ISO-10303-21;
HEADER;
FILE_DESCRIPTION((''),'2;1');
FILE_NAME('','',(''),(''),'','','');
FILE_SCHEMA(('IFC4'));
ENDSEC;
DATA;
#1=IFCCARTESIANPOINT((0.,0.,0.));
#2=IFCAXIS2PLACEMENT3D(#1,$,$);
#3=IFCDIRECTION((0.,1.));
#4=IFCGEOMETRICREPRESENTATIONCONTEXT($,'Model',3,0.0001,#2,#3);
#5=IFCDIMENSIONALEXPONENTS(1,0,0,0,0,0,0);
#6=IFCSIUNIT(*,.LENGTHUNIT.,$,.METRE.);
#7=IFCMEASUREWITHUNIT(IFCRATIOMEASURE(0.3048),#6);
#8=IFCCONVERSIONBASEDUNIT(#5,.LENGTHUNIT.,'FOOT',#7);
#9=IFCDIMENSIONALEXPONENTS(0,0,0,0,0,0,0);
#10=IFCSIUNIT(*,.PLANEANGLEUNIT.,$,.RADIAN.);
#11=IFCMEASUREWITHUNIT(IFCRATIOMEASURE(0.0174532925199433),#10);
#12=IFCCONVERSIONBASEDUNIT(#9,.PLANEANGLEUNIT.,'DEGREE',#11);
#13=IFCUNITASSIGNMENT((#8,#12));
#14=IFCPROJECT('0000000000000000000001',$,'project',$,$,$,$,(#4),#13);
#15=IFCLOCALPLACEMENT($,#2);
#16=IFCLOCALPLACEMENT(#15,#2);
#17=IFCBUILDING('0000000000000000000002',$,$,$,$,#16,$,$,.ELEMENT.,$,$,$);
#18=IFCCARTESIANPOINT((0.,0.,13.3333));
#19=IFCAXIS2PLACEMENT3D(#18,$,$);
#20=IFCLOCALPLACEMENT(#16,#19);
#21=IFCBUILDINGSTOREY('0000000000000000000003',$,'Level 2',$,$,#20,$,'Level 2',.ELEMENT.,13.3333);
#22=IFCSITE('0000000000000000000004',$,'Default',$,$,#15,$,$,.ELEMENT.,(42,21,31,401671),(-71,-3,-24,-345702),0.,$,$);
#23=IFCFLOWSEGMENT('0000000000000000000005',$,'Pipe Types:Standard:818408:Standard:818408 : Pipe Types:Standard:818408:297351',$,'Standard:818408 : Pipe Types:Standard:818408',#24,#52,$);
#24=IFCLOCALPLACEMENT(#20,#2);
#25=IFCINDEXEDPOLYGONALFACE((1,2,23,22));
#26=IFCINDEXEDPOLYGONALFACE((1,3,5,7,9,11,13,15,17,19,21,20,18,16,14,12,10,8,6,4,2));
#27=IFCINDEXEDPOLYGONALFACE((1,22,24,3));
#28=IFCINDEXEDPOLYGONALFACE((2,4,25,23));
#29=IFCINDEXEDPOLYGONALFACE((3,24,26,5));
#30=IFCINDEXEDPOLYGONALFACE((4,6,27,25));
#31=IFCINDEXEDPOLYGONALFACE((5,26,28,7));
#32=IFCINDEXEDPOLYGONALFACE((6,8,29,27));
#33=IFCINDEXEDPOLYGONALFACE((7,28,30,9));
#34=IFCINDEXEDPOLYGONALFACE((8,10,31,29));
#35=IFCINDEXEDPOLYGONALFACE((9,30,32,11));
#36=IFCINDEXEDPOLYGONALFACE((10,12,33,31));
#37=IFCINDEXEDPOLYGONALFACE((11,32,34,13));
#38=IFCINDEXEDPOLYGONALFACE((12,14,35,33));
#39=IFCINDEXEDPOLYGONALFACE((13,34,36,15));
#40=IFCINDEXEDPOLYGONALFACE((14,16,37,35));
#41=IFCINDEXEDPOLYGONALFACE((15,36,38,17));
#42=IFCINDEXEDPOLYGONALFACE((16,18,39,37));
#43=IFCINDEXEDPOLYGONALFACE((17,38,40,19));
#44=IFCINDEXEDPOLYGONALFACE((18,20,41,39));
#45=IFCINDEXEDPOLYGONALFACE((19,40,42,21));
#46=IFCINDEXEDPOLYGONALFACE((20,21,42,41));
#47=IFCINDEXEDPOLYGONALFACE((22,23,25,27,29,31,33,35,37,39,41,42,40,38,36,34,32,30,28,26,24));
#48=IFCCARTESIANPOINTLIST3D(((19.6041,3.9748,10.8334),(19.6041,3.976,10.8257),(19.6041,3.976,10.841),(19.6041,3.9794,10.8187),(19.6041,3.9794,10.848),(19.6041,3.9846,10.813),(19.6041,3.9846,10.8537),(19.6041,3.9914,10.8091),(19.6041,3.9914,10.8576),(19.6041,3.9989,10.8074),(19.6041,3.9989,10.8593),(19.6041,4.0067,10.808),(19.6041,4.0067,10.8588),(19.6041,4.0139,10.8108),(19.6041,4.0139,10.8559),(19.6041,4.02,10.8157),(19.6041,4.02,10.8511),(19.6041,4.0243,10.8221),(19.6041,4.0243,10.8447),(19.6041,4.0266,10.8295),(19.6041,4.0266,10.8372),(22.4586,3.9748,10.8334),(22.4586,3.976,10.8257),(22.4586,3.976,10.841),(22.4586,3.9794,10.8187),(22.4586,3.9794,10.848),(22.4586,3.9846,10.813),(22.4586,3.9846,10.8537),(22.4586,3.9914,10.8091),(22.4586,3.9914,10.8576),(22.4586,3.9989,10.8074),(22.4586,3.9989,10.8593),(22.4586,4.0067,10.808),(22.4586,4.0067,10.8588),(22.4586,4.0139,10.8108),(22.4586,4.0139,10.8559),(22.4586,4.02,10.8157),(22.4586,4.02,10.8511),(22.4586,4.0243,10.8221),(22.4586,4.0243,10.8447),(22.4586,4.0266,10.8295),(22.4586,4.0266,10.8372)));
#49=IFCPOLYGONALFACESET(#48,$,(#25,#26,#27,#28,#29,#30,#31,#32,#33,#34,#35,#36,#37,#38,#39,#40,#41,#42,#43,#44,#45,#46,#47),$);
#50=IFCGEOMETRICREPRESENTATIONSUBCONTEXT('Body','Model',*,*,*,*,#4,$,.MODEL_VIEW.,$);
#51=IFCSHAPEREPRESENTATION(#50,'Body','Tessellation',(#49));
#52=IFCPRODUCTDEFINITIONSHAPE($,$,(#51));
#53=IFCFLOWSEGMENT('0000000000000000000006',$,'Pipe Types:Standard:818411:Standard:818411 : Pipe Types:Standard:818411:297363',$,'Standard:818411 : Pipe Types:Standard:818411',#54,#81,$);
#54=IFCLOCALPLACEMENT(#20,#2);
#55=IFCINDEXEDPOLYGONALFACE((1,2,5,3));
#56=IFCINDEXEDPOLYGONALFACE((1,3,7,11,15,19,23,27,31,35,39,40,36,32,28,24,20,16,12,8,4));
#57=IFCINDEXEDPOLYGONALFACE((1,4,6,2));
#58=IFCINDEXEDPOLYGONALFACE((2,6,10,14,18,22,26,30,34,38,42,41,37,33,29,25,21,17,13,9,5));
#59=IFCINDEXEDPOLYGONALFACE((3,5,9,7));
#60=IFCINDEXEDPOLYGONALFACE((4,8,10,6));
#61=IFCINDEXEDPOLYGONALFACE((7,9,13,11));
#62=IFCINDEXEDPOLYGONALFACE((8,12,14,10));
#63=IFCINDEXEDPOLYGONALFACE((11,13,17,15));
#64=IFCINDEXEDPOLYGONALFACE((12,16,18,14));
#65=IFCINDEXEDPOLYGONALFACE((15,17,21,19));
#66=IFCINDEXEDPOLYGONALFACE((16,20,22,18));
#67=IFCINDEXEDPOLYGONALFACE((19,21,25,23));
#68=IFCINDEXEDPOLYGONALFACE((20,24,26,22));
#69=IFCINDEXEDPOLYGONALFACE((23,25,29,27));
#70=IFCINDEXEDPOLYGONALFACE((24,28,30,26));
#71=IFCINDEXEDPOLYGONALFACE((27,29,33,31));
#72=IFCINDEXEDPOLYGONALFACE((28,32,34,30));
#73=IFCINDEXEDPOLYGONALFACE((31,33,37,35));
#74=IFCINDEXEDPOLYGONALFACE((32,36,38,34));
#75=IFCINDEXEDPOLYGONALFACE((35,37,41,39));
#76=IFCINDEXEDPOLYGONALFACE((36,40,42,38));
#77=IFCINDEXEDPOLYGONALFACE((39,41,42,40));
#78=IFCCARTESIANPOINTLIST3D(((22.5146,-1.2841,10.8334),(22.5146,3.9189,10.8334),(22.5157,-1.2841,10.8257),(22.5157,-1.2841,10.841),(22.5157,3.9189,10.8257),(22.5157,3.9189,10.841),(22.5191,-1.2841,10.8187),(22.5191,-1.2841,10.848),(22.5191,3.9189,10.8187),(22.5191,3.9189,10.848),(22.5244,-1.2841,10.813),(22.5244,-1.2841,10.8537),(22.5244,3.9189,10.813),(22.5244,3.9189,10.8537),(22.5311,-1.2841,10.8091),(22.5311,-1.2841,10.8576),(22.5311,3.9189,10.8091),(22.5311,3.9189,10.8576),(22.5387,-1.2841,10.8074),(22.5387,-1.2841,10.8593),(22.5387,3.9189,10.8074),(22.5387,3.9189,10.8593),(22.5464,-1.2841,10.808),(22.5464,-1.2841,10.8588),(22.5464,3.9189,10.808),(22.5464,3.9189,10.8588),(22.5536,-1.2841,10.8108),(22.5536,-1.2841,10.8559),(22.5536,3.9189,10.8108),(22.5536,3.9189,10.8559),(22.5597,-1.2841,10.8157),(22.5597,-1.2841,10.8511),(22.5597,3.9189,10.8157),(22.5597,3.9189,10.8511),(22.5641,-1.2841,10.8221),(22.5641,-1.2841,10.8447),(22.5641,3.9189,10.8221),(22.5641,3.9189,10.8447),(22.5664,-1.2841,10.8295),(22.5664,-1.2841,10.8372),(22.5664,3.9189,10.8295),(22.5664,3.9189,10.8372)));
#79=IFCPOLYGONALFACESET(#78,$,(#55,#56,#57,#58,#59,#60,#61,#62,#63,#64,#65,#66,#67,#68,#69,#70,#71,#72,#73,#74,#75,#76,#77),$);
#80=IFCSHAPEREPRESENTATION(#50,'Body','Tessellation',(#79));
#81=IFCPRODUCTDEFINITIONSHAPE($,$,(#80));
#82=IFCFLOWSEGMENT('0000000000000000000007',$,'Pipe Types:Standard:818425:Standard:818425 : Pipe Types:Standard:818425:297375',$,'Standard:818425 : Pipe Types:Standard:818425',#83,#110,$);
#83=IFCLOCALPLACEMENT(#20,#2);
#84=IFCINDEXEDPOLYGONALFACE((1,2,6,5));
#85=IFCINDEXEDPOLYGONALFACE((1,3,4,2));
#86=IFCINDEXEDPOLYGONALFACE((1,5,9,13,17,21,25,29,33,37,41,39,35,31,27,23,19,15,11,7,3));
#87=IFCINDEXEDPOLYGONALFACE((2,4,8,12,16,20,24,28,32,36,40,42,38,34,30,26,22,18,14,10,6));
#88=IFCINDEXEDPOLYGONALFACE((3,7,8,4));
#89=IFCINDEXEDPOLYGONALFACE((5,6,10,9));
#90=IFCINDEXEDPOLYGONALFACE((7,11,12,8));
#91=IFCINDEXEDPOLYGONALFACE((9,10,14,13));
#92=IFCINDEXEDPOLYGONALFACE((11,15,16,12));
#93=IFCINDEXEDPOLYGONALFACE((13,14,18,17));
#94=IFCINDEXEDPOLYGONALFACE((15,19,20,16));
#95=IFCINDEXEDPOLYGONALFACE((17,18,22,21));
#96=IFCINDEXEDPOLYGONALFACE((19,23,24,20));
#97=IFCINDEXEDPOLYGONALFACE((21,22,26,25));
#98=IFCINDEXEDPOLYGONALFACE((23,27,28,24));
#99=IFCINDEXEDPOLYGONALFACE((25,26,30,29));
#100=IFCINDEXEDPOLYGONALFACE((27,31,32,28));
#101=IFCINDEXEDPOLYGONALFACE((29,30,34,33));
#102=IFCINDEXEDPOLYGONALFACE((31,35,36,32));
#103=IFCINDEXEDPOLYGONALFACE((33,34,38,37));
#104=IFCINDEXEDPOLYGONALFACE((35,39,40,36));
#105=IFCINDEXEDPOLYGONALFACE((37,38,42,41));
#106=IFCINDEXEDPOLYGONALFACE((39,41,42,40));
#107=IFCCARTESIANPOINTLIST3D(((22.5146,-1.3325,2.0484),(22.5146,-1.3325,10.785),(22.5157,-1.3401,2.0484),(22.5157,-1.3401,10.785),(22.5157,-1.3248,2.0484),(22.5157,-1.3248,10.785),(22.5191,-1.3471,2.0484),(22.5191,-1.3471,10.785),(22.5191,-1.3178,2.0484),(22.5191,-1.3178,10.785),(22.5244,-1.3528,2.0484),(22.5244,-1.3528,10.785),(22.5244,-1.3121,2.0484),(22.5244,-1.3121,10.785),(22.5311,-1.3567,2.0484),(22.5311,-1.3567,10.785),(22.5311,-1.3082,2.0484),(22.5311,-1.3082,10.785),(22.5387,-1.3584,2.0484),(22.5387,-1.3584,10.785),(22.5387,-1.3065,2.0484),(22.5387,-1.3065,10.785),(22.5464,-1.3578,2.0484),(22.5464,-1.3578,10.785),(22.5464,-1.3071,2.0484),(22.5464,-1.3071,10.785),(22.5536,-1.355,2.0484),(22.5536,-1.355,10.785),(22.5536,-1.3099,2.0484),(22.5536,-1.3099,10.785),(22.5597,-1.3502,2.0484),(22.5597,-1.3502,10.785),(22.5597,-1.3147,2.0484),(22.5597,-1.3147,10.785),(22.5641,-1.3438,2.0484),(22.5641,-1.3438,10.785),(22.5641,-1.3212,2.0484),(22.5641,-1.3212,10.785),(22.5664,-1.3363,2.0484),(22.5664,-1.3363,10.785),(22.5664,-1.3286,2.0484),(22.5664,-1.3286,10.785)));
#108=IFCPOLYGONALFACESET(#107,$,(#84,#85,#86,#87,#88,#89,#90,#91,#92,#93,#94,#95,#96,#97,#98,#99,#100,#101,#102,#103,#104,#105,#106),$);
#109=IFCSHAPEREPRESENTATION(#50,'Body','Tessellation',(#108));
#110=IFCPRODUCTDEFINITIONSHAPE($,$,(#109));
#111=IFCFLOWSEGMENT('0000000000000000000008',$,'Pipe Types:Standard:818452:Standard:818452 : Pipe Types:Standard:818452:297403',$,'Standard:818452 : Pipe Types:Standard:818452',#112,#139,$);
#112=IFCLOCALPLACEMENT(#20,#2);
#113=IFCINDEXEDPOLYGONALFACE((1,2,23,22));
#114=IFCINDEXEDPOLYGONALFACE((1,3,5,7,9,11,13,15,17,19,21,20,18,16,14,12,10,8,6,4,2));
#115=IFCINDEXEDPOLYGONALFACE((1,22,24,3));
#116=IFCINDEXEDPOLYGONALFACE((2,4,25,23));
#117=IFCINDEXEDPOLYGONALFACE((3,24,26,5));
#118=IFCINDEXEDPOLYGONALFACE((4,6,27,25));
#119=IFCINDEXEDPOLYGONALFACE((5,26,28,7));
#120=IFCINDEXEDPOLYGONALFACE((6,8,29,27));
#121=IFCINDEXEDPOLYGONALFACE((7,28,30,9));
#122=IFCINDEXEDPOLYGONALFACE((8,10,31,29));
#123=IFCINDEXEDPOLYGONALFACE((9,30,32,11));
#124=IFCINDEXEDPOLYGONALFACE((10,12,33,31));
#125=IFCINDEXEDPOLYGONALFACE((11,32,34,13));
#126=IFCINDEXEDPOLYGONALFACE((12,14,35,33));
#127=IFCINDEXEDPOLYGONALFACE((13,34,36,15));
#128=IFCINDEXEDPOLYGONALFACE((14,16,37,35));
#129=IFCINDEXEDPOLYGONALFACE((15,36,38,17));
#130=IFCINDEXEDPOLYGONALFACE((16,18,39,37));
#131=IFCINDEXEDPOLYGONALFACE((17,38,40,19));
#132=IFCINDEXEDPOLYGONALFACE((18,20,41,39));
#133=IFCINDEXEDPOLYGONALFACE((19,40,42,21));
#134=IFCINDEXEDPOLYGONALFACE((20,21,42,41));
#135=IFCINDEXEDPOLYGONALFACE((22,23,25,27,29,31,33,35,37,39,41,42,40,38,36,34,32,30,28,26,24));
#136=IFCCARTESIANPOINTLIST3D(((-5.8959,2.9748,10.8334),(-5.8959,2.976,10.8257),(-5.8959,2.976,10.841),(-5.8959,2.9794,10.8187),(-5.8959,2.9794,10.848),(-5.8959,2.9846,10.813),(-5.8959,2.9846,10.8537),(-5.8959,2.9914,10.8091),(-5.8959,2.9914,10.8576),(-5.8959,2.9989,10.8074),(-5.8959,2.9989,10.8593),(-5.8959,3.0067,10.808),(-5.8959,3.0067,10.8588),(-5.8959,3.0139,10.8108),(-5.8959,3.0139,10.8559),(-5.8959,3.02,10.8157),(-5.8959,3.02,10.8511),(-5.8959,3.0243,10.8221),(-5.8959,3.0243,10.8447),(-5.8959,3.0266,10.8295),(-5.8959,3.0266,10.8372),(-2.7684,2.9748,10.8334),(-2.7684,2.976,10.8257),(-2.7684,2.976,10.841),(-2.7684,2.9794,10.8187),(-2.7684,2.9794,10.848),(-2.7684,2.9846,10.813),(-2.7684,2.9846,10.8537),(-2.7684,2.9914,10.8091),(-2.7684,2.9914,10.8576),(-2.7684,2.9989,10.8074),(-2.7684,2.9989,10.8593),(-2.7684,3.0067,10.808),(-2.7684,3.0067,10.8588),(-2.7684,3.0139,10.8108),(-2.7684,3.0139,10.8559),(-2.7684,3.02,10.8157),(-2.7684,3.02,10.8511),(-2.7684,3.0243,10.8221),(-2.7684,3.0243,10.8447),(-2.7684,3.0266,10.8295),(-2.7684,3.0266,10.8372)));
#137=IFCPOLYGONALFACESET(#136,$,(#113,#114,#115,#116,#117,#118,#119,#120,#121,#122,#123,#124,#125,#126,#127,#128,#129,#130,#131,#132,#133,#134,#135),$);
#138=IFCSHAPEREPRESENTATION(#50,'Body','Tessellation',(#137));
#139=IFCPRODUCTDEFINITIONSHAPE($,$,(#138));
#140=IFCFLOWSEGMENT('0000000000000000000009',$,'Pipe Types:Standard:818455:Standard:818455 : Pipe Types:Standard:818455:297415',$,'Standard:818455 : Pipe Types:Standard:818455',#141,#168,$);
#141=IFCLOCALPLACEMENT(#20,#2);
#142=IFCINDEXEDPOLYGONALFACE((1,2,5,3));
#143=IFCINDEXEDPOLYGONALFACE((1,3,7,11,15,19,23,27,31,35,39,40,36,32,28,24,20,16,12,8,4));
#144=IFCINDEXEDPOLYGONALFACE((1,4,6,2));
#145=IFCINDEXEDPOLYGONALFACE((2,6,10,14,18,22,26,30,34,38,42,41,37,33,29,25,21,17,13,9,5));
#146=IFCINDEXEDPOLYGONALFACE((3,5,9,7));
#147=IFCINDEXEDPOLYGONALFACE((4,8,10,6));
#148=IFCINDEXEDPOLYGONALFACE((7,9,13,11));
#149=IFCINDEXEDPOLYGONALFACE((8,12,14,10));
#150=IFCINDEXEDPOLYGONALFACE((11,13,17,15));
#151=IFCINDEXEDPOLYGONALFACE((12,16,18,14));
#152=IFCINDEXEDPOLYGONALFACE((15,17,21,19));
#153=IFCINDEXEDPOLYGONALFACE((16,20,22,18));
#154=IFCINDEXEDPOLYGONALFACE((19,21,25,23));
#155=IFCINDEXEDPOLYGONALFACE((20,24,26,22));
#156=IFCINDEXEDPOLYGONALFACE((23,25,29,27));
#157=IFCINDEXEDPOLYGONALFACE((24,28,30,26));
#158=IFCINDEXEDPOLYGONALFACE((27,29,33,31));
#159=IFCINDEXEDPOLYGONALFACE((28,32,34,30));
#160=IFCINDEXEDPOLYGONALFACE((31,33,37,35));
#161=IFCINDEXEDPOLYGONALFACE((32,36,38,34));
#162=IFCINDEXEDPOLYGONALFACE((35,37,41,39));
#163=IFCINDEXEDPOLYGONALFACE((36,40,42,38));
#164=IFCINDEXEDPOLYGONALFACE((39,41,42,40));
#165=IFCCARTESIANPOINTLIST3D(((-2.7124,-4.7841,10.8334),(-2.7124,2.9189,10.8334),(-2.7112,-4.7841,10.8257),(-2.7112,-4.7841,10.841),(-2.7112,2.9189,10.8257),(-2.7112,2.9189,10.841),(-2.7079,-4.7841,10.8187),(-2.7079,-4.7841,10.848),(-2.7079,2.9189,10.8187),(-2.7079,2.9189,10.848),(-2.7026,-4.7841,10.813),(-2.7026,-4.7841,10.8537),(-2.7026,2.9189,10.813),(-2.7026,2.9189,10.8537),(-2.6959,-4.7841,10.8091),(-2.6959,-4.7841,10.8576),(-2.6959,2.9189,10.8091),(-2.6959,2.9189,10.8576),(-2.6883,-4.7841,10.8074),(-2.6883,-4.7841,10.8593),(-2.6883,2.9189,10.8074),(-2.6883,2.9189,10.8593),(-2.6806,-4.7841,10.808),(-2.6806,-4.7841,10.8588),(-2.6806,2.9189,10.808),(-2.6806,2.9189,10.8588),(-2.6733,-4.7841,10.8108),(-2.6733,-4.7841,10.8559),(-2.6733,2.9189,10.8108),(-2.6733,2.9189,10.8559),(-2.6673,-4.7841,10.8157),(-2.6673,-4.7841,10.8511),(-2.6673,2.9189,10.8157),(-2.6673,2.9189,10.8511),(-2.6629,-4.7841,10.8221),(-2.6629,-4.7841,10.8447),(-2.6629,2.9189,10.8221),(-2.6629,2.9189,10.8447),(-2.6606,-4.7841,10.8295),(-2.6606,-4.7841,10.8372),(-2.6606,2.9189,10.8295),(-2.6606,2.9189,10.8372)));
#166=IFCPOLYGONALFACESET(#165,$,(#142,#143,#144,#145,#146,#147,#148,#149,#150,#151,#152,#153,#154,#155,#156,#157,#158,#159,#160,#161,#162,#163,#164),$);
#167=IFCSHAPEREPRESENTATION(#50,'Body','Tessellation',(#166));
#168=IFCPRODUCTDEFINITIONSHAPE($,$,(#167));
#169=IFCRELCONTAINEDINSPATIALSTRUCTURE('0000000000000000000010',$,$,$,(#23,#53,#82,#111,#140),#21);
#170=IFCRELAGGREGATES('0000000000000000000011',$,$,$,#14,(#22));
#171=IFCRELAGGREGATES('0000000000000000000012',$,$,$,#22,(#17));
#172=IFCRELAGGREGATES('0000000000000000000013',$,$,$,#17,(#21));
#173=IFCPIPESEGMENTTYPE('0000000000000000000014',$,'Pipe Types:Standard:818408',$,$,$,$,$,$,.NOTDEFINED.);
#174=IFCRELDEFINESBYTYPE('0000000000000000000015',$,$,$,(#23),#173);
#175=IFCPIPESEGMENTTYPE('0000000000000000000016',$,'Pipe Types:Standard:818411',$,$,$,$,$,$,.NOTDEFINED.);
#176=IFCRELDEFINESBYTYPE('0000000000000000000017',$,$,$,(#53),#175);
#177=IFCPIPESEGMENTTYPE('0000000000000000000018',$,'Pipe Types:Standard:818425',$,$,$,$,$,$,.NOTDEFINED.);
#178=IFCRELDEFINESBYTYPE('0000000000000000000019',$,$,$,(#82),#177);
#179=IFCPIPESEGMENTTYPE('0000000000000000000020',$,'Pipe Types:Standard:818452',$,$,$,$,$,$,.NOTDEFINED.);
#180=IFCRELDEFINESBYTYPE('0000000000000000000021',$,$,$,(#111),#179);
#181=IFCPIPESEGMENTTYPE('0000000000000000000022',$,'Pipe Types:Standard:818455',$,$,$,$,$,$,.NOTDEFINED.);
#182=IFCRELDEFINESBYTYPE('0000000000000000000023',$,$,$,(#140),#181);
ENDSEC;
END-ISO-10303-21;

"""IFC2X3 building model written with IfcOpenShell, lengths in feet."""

from ifc_helpers import new_model, entity, si_unit, converted_unit, direction, frame, origin, origin_2d_with_axis, place, context, subcontext, project, spatial, circle, extrude, source, transform, mapped, type_object, type_shapes, element, save


model = new_model("IFC2X3")

# Units and contexts
model_context = context("Model", 3, precision=0.0001, world=origin(), true_north=direction((0.0, 1.0)))
body_context = subcontext(model_context, "Body", "Model", "MODEL_VIEW")
ifc_project = project(units=[converted_unit("LENGTHUNIT", "FOOT", entity("IfcRatioMeasure", 0.3048), si_unit("LENGTHUNIT", "METRE"), dimensions=[1, 0, 0, 0, 0, 0, 0]), converted_unit("PLANEANGLEUNIT", "DEGREE", entity("IfcRatioMeasure", 0.0174532925199433), si_unit("PLANEANGLEUNIT", "RADIAN"), dimensions=[0, 0, 0, 0, 0, 0, 0])], contexts=[model_context])

# Site, building, storey
site_placement = place(None, origin())
site = spatial("IfcSite", under=ifc_project, at=site_placement, Name="Default", CompositionType="ELEMENT", RefLatitude=(42, 21, 31, 401671), RefLongitude=(-71, -3, -24, -345702), RefElevation=0.0)
building_placement = place(site_placement, origin())
building = spatial("IfcBuilding", under=site, at=building_placement, CompositionType="ELEMENT")
storey_placement = place(building_placement, frame((0.0, 0.0, 13.3333)))
storey = spatial("IfcBuildingStorey", under=building, at=storey_placement, Name="Level 2", LongName="Level 2", CompositionType="ELEMENT", Elevation=13.3333)

# Flow segments
pipe_segment_type_1 = type_object("IfcPipeSegmentType", Name="Pipe Types:Standard:818408", PredefinedType="NOTDEFINED")
shared_shape_1 = source(origin(), body_context, "Body", "SweptSolid", [
    extrude(circle(Radius=0.026, at=origin_2d_with_axis()), frame((19.6041, 4.0009, 24.1667), z_axis=(1.0, 0.0, 0.0), x_axis=(0.0, -1.0, 0.0)), (0.0, 0.0, 1.0), 2.8545),
])
type_shapes(pipe_segment_type_1, [shared_shape_1])
flow_segment_1_placement = place(building_placement, origin())
element("IfcFlowSegment", 1, at=flow_segment_1_placement, inside=storey, type_object=pipe_segment_type_1, Name="Pipe Types:Standard:818408:Standard:818408 : Pipe Types:Standard:818408:297351", ObjectType="Standard:818408 : Pipe Types:Standard:818408", context=body_context, shape_type="MappedRepresentation", body=[
    mapped(shared_shape_1, transform((0.0, 0.0, 0.0), scale=1.0)),
])
pipe_segment_type_2 = type_object("IfcPipeSegmentType", Name="Pipe Types:Standard:818411", PredefinedType="NOTDEFINED")
shared_shape_2 = source(origin(), body_context, "Body", "SweptSolid", [
    extrude(circle(Radius=0.026, at=origin_2d_with_axis()), frame((22.5406, -1.2841, 24.1667), z_axis=(0.0, 1.0, 0.0), x_axis=(-1.0, 0.0, 0.0)), (0.0, 0.0, 1.0), 5.203),
])
type_shapes(pipe_segment_type_2, [shared_shape_2])
flow_segment_2_placement = place(building_placement, origin())
element("IfcFlowSegment", 2, at=flow_segment_2_placement, inside=storey, type_object=pipe_segment_type_2, Name="Pipe Types:Standard:818411:Standard:818411 : Pipe Types:Standard:818411:297363", ObjectType="Standard:818411 : Pipe Types:Standard:818411", context=body_context, shape_type="MappedRepresentation", body=[
    mapped(shared_shape_2, transform((0.0, 0.0, 0.0), scale=1.0)),
])
pipe_segment_type_3 = type_object("IfcPipeSegmentType", Name="Pipe Types:Standard:818425", PredefinedType="NOTDEFINED")
shared_shape_3 = source(origin(), body_context, "Body", "SweptSolid", [
    extrude(circle(Radius=0.026, at=origin_2d_with_axis()), frame((22.5406, -1.3325, 15.3817), z_axis=(0.0, 0.0, 1.0), x_axis=(-1.0, 0.0, 0.0)), (0.0, 0.0, 1.0), 8.7367),
])
type_shapes(pipe_segment_type_3, [shared_shape_3])
flow_segment_3_placement = place(building_placement, origin())
element("IfcFlowSegment", 3, at=flow_segment_3_placement, inside=storey, type_object=pipe_segment_type_3, Name="Pipe Types:Standard:818425:Standard:818425 : Pipe Types:Standard:818425:297375", ObjectType="Standard:818425 : Pipe Types:Standard:818425", context=body_context, shape_type="MappedRepresentation", body=[
    mapped(shared_shape_3, transform((0.0, 0.0, 0.0), scale=1.0)),
])
pipe_segment_type_4 = type_object("IfcPipeSegmentType", Name="Pipe Types:Standard:818452", PredefinedType="NOTDEFINED")
shared_shape_4 = source(origin(), body_context, "Body", "SweptSolid", [
    extrude(circle(Radius=0.026, at=origin_2d_with_axis()), frame((-5.8959, 3.0009, 24.1667), z_axis=(1.0, 0.0, 0.0), x_axis=(0.0, -1.0, 0.0)), (0.0, 0.0, 1.0), 3.1275),
])
type_shapes(pipe_segment_type_4, [shared_shape_4])
flow_segment_4_placement = place(building_placement, origin())
element("IfcFlowSegment", 4, at=flow_segment_4_placement, inside=storey, type_object=pipe_segment_type_4, Name="Pipe Types:Standard:818452:Standard:818452 : Pipe Types:Standard:818452:297403", ObjectType="Standard:818452 : Pipe Types:Standard:818452", context=body_context, shape_type="MappedRepresentation", body=[
    mapped(shared_shape_4, transform((0.0, 0.0, 0.0), scale=1.0)),
])
pipe_segment_type_5 = type_object("IfcPipeSegmentType", Name="Pipe Types:Standard:818455", PredefinedType="NOTDEFINED")
shared_shape_5 = source(origin(), body_context, "Body", "SweptSolid", [
    extrude(circle(Radius=0.026, at=origin_2d_with_axis()), frame((-2.6864, -4.7841, 24.1667), z_axis=(0.0, 1.0, 0.0), x_axis=(-1.0, 0.0, 0.0)), (0.0, 0.0, 1.0), 7.703),
])
type_shapes(pipe_segment_type_5, [shared_shape_5])
flow_segment_5_placement = place(building_placement, origin())
element("IfcFlowSegment", 5, at=flow_segment_5_placement, inside=storey, type_object=pipe_segment_type_5, Name="Pipe Types:Standard:818455:Standard:818455 : Pipe Types:Standard:818455:297415", ObjectType="Standard:818455 : Pipe Types:Standard:818455", context=body_context, shape_type="MappedRepresentation", body=[
    mapped(shared_shape_5, transform((0.0, 0.0, 0.0), scale=1.0)),
])

save(model, "model.ifc")
